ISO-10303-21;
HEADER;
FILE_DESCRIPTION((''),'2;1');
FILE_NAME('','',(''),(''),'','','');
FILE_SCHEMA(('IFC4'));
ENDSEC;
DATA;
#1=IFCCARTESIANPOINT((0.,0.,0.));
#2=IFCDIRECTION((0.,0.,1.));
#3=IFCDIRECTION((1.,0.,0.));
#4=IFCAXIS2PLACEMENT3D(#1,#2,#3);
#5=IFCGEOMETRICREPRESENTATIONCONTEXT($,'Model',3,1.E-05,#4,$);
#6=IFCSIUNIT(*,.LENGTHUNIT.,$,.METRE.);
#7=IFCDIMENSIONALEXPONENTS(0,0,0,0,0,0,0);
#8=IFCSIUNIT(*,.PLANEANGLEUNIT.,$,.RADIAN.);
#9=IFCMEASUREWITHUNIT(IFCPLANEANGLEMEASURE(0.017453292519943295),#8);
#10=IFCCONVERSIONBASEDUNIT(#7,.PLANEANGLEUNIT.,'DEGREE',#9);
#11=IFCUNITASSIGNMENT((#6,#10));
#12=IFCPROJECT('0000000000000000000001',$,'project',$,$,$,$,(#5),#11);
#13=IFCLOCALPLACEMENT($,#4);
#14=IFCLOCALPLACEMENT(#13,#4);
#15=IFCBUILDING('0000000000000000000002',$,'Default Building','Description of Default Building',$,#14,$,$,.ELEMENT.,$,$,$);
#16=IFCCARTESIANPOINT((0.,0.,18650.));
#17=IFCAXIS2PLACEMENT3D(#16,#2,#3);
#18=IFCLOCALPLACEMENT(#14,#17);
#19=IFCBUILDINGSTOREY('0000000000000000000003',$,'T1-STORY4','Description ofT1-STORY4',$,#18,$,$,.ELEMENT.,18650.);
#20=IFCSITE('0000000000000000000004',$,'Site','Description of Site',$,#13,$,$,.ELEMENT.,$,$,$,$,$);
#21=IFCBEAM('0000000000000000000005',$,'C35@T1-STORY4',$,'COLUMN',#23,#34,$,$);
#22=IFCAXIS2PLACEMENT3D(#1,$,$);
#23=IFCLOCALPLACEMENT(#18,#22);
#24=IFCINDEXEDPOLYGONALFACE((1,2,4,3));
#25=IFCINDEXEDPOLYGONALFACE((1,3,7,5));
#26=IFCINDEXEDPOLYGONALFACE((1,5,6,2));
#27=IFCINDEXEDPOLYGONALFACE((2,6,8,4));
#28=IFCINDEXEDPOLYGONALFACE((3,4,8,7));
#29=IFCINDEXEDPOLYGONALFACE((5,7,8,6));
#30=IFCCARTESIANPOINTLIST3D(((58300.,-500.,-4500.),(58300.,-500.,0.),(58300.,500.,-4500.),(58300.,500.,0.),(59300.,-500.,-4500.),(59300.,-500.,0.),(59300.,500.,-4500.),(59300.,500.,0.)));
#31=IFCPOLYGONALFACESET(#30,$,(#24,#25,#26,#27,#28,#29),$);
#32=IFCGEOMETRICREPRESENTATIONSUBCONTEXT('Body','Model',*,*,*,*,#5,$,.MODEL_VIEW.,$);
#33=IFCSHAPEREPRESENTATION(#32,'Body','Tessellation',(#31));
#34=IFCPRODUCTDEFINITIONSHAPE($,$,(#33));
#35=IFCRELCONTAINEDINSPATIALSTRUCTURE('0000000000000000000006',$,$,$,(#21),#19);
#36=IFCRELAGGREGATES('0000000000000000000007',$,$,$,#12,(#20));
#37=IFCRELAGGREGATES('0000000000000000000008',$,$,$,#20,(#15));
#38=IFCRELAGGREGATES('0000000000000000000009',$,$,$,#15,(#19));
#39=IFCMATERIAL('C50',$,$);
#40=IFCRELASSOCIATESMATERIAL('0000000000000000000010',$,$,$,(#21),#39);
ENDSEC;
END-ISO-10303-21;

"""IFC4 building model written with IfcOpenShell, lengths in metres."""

from ifc_helpers import new_model, entity, si_unit, converted_unit, frame, origin_with_axes, place, context, subcontext, project, spatial, rectangle, extrude, material, element, save


model = new_model("IFC4")

# Units and contexts
model_context = context("Model", 3, precision=1e-05, world=origin_with_axes())
body_context = subcontext(model_context, "Body", "Model", "MODEL_VIEW")
ifc_project = project(units=[si_unit("LENGTHUNIT", "METRE"), converted_unit("PLANEANGLEUNIT", "DEGREE", entity("IfcPlaneAngleMeasure", 0.017453292519943295), si_unit("PLANEANGLEUNIT", "RADIAN"), dimensions=[0, 0, 0, 0, 0, 0, 0])], contexts=[model_context])

# Site, building, storey
site_placement = place(None, origin_with_axes())
site = spatial("IfcSite", under=ifc_project, at=site_placement, Name="Site", Description="Description of Site", CompositionType="ELEMENT")
building_placement = place(site_placement, origin_with_axes())
building = spatial("IfcBuilding", under=site, at=building_placement, Name="Default Building", Description="Description of Default Building", CompositionType="ELEMENT")
storey_placement = place(building_placement, frame((0.0, 0.0, 18650.0), z_axis=(0.0, 0.0, 1.0), x_axis=(1.0, 0.0, 0.0)))
storey = spatial("IfcBuildingStorey", under=building, at=storey_placement, Name="T1-STORY4", Description="Description ofT1-STORY4", CompositionType="ELEMENT", Elevation=18650.0)

# Beam
ifc_material_1 = material(Name="C50")
for number, where, z_axis, x_axis, name in (
    (1, (58800.0, 0.0, -4500.0), (0.0, 0.0, 1.0), (-1.0, 0.0, 0.0), "C35@T1-STORY4"),
):
    element("IfcBeam", number, at=place(storey_placement, frame(where, z_axis=z_axis, x_axis=x_axis)), inside=storey, material=ifc_material_1, Name=name, ObjectType="COLUMN", context=body_context, shape_type="SweptSolid", body=[
        extrude(rectangle(XDim=1000.0, YDim=1000.0), origin_with_axes(), (0.0, 0.0, 1.0), 4500.0),
    ])

save(model, "model.ifc")
